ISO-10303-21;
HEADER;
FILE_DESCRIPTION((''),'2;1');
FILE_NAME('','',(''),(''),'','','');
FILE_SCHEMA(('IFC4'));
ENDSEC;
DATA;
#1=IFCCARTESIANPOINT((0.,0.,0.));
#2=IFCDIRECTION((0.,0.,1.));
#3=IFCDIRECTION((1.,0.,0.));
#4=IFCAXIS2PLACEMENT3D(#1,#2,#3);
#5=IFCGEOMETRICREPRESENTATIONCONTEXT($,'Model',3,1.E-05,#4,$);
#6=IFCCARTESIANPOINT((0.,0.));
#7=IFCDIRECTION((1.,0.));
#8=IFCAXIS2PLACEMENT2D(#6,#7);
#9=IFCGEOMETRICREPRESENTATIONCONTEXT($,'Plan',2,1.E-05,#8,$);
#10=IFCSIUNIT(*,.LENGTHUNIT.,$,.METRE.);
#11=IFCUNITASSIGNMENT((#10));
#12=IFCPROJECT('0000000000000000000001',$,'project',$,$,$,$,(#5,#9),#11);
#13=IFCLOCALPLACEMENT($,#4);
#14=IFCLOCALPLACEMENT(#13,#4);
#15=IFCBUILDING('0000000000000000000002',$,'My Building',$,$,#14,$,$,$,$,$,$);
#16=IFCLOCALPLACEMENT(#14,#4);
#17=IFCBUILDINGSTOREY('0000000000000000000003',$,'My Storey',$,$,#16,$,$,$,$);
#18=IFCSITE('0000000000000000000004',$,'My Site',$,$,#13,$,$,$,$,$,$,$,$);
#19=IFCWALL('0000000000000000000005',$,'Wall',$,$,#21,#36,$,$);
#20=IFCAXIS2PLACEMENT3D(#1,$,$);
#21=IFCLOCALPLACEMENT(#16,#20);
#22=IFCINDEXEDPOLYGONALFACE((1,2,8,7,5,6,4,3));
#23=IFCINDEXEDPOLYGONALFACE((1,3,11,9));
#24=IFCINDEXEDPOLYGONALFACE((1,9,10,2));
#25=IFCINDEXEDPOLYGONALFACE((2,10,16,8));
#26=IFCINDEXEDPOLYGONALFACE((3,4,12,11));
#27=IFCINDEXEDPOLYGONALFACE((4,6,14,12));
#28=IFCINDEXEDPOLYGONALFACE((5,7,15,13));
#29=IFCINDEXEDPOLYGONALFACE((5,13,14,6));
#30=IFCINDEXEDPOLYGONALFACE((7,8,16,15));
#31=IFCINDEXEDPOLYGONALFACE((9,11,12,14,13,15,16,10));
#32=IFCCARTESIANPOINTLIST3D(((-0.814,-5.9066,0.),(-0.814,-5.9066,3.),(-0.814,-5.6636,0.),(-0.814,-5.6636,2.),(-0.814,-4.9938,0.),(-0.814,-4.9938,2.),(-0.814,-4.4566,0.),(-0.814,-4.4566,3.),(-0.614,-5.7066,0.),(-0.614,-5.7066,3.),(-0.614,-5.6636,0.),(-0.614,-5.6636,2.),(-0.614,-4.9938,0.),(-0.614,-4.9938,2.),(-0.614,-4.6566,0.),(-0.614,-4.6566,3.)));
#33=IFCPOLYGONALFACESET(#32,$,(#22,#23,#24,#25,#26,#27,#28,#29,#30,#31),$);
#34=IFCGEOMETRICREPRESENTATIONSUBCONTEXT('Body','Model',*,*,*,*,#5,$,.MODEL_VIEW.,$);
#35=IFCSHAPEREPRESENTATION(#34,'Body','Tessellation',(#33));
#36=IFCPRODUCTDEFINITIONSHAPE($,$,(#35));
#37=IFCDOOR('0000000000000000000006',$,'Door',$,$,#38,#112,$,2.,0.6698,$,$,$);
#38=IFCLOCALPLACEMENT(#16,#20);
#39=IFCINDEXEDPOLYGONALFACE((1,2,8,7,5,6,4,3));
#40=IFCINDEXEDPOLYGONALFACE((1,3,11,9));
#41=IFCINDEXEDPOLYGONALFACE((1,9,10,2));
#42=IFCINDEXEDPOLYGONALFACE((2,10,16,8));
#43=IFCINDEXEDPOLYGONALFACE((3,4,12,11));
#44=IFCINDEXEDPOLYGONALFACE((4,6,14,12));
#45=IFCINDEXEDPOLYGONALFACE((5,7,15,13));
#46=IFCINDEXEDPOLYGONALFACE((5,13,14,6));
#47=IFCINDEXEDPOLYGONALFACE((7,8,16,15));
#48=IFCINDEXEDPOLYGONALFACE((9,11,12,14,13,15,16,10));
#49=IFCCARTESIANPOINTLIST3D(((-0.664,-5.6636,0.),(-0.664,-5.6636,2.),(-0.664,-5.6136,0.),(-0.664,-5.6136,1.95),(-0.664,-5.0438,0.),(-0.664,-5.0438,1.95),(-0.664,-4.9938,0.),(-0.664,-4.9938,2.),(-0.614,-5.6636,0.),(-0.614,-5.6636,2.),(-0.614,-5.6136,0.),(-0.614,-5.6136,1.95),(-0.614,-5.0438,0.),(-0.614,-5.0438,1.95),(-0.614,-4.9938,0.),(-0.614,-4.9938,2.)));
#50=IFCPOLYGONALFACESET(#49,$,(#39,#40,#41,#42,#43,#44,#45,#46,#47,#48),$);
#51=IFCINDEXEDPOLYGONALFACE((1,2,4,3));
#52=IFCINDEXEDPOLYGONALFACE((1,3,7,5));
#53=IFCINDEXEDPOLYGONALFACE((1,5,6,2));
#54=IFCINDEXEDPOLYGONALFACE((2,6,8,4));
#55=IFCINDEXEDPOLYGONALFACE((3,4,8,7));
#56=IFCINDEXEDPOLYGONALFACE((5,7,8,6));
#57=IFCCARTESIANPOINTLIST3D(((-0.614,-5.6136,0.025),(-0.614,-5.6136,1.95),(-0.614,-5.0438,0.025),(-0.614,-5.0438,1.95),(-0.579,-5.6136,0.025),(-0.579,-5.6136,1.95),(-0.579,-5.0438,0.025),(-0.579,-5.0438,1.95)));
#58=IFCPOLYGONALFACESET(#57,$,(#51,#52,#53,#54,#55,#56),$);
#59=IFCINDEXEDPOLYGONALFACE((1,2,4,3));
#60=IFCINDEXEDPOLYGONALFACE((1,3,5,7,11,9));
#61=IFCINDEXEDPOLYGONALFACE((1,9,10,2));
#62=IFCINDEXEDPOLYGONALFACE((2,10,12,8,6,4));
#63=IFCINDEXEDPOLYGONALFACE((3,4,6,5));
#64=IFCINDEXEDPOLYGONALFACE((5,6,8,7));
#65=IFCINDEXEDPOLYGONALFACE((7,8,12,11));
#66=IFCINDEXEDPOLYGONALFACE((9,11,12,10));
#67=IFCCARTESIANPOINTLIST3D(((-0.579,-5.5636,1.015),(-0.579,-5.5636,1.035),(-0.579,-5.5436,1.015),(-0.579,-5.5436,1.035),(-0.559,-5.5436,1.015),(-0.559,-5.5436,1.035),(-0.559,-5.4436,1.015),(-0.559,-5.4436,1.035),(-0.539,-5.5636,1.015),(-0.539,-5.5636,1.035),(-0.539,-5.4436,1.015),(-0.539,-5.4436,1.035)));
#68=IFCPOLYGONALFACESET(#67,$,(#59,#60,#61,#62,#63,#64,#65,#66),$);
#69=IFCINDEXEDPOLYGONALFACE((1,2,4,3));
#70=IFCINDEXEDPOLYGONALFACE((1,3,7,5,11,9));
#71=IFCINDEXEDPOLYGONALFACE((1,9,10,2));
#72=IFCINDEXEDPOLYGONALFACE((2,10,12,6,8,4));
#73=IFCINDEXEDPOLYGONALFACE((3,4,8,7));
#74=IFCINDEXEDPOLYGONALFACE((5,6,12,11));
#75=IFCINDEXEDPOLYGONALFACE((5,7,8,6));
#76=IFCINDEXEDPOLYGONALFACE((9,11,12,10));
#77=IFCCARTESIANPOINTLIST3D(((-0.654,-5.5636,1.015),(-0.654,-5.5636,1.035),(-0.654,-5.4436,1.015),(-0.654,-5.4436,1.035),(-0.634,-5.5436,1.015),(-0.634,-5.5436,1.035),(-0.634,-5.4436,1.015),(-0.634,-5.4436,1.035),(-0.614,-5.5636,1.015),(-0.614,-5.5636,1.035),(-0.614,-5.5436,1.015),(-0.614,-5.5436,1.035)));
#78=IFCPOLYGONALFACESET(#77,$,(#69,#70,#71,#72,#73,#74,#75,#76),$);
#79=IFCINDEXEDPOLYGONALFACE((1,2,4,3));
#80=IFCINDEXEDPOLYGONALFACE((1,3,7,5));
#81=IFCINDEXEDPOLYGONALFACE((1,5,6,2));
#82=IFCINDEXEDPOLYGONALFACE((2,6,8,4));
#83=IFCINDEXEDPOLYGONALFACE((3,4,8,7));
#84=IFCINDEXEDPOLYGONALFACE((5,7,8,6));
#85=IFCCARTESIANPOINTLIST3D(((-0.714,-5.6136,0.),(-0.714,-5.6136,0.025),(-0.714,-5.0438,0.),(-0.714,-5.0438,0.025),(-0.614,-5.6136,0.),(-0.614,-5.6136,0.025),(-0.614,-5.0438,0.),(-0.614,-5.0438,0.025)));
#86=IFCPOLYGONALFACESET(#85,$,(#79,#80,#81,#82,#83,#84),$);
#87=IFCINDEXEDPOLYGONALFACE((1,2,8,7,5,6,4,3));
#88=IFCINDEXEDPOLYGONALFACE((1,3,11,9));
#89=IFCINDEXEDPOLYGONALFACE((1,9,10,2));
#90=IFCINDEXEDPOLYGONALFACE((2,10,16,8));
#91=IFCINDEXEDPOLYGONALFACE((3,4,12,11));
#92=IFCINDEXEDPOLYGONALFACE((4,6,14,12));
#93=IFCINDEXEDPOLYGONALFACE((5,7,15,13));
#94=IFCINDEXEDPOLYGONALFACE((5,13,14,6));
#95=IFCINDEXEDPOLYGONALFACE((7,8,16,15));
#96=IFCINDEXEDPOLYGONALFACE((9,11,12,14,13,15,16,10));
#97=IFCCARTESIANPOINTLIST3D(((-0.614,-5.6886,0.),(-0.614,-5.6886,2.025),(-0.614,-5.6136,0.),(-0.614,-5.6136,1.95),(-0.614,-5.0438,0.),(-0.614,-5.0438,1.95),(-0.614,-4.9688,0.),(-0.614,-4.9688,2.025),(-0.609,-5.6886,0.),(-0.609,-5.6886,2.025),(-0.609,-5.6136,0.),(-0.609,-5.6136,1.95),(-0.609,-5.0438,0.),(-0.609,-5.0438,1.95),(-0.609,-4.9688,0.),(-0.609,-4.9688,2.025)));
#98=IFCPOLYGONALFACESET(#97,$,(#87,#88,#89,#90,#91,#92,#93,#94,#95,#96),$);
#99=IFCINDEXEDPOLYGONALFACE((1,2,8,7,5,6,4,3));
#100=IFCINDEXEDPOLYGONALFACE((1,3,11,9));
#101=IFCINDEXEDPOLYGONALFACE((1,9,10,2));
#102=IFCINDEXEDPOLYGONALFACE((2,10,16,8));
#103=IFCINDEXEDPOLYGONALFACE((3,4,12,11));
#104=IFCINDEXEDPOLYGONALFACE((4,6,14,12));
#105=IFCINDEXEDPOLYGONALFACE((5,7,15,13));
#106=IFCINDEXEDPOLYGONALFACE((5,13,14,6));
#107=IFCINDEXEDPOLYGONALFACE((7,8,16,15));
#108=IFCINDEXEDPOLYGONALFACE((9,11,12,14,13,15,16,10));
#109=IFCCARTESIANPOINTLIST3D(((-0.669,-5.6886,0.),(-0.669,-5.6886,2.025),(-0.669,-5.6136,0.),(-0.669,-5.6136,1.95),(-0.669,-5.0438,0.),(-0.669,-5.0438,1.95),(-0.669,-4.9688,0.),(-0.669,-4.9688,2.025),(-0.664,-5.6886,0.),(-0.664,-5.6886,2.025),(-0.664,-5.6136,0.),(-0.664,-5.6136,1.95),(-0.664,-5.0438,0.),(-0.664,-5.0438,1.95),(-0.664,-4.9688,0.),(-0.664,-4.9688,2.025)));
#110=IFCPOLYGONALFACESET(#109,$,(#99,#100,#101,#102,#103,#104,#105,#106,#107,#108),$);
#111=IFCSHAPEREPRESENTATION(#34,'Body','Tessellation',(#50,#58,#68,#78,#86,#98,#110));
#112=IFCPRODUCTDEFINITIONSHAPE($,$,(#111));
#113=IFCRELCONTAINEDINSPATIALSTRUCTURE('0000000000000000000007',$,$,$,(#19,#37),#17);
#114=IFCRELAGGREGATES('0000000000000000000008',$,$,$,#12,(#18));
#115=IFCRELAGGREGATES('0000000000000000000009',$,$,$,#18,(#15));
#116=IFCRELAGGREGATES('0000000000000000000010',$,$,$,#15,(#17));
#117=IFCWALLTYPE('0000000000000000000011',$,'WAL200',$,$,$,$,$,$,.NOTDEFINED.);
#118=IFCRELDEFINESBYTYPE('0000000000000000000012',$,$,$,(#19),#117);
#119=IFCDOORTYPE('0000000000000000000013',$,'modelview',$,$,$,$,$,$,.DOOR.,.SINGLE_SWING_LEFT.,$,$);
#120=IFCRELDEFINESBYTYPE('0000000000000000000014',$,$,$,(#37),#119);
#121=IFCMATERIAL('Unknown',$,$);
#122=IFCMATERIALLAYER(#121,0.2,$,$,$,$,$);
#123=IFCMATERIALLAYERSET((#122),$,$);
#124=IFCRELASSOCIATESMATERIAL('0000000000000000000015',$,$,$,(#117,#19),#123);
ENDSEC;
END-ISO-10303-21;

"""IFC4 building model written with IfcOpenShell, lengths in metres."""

from ifc_helpers import new_model, entity, si_unit, frame, origin_with_axes, origin_2d_with_axis, place, context, subcontext, project, spatial, line, indexed_curve, outline, extrude, shape, source, transform, mapped, material, layer, layer_set, layer_usage, type_object, type_shapes, element, fill, save


model = new_model("IFC4")

# Units and contexts
model_context = context("Model", 3, precision=1e-05, world=origin_with_axes())
plan_context = context("Plan", 2, precision=1e-05, world=origin_2d_with_axis())
body_context_1 = subcontext(model_context, "Body", "Model", "MODEL_VIEW")
body_context_2 = subcontext(plan_context, "Body", "Plan", "PLAN_VIEW")
ifc_project = project(units=[si_unit("LENGTHUNIT", "METRE")], contexts=[model_context, plan_context])

# Site, building, storey
site_placement = place(None, origin_with_axes())
site = spatial("IfcSite", under=ifc_project, at=site_placement, Name="My Site")
building_placement = place(site_placement, origin_with_axes())
building = spatial("IfcBuilding", under=site, at=building_placement, Name="My Building")
storey_placement = place(building_placement, origin_with_axes())
storey = spatial("IfcBuildingStorey", under=building, at=storey_placement, Name="My Storey")

# Shared definitions
ifc_material = material(Name="Unknown")

# Shared definitions
shared_shape_1 = source(origin_with_axes(), body_context_1, "Body", "SweptSolid", [
    extrude(outline(indexed_curve([(0.0, 0.0), (0.6698, 0.0), (0.6698, 2.0), (0.0, 2.0)], segments=[line(1, 2, 3, 4, 1)])), frame((0.0, -0.6, 0.0), z_axis=(0.0, -1.0, 0.0), x_axis=(1.0, 0.0, 0.0)), (0.0, 0.0, -1.0), 1.2),
])
door_type_1 = type_object("IfcDoorType", Name="modelview", OperationType="SINGLE_SWING_LEFT", PredefinedType="DOOR")
shared_shape_2 = source(origin_with_axes(), body_context_1, "Body", "SweptSolid", [
    extrude(outline(indexed_curve([(0.0, 0.0), (0.0, 2.0), (0.6698, 2.0), (0.6698, 0.0), (0.6198, 0.0), (0.6198, 1.95), (0.05, 1.95), (0.05, 0.0)], segments=[line(1, 2, 3, 4, 5, 6, 7, 8, 1)])), frame((0.0, 0.0, 0.0), z_axis=(0.0, -1.0, 0.0), x_axis=(1.0, 0.0, 0.0)), (0.0, 0.0, -1.0), 0.05),
    extrude(outline(indexed_curve([(0.0, 0.0), (0.5698, 0.0), (0.5698, 0.035), (0.0, 0.035)], segments=[line(1, 2, 3, 4, 1)])), frame((0.05, -0.035, 0.025), z_axis=(0.0, 0.0, 1.0), x_axis=(1.0, 0.0, 0.0)), (0.0, 0.0, 1.0), 1.925),
    extrude(outline(indexed_curve([(0.0, 0.0), (0.0, -0.04), (0.12, -0.04), (0.12, -0.02), (0.02, -0.02), (0.02, 0.0)], segments=[line(1, 2, 3, 4, 5, 6, 1)])), frame((0.1, -0.035, 1.015), z_axis=(0.0, 0.0, 1.0), x_axis=(1.0, 0.0, 0.0)), (0.0, 0.0, 1.0), 0.02),
    extrude(outline(indexed_curve([(0.0, 0.0), (0.0, 0.04), (0.12, 0.04), (0.12, 0.02), (0.02, 0.02), (0.02, 0.0)], segments=[line(1, 2, 3, 4, 5, 6, 1)])), frame((0.1, 0.0, 1.015), z_axis=(0.0, 0.0, 1.0), x_axis=(1.0, 0.0, 0.0)), (0.0, 0.0, 1.0), 0.02),
    extrude(outline(indexed_curve([(0.0, 0.0), (0.5698, 0.0), (0.5698, 0.1), (0.0, 0.1)], segments=[line(1, 2, 3, 4, 1)])), frame((0.05, 0.0, 0.0), z_axis=(0.0, 0.0, 1.0), x_axis=(1.0, 0.0, 0.0)), (0.0, 0.0, 1.0), 0.025),
    extrude(outline(indexed_curve([(0.0, 0.0), (0.0, 2.025), (0.7198, 2.025), (0.7198, 0.0), (0.6448, 0.0), (0.6448, 1.95), (0.075, 1.95), (0.075, 0.0)], segments=[line(1, 2, 3, 4, 5, 6, 7, 8, 1)])), frame((-0.025, -0.005, 0.0), z_axis=(0.0, -1.0, 0.0), x_axis=(1.0, 0.0, 0.0)), (0.0, 0.0, -1.0), 0.005),
    extrude(outline(indexed_curve([(0.0, 0.0), (0.0, 2.025), (0.7198, 2.025), (0.7198, 0.0), (0.6448, 0.0), (0.6448, 1.95), (0.075, 1.95), (0.075, 0.0)], segments=[line(1, 2, 3, 4, 5, 6, 7, 8, 1)])), frame((-0.025, 0.05, 0.0), z_axis=(0.0, -1.0, 0.0), x_axis=(1.0, 0.0, 0.0)), (0.0, 0.0, -1.0), 0.005),
])
shared_shape_3 = source(origin_with_axes(), body_context_2, "Body", "Curve2D", [
    entity("IfcIndexedPolyCurve", entity("IfcCartesianPointList2D", [[0.0, 0.0], [0.05, 0.0], [0.05, 0.05], [0.0, 0.05]]), [entity("IfcLineIndex", [1, 2, 3, 4, 1])]),
    entity("IfcIndexedPolyCurve", entity("IfcCartesianPointList2D", [[0.6698, 0.0], [0.6198, 0.0], [0.6198, 0.05], [0.6698, 0.05]]), [entity("IfcLineIndex", [1, 2, 3, 4, 1])]),
    entity("IfcIndexedPolyCurve", entity("IfcCartesianPointList2D", [[0.9047, -0.035], [0.3349, -0.035], [0.3349, 0.0], [0.9047, 0.0]]), [entity("IfcLineIndex", [1, 2, 3, 4, 1])]),
])
type_shapes(door_type_1, [shared_shape_2, shared_shape_3])

# Shared definitions
ifc_layer_1 = layer(ifc_material, 0.2)
ifc_layer_set_1 = layer_set([ifc_layer_1])
wall_type_1 = type_object("IfcWallType", Name="WAL200", PredefinedType="NOTDEFINED", material=ifc_layer_set_1)

# Wall, opening, door
ifc_layer_usage_1 = layer_usage(ifc_layer_set_1, "AXIS2", "POSITIVE", 0.0)
wall_1_placement = place(storey_placement, frame((-0.814, -4.4566, 0.0), z_axis=(0.0, 0.0, 1.0), x_axis=(0.0, -1.0, 0.0)))
wall_1 = element("IfcWall", 1, at=wall_1_placement, inside=storey, type_object=wall_type_1, material=ifc_layer_usage_1, Name="Wall", context=body_context_1, shape_type="SweptSolid", body=[
    extrude(outline(indexed_curve([(0.0, 0.0), (0.2, 0.2), (1.25, 0.2), (1.45, 0.0)], segments=[line(1, 2, 3, 4, 1)])), origin_with_axes(), (0.0, 0.0, 1.0), 3.0),
])
opening_1_placement = place(wall_1_placement, frame((1.2071, 0.2, 0.0), z_axis=(0.0, 0.0, 1.0), x_axis=(-1.0, 0.0, 0.0)))
opening_1 = element("IfcOpeningElement", 2, at=opening_1_placement, cuts=wall_1, PredefinedType="OPENING", context=body_context_1, shape_type="MappedRepresentation", body=[
    mapped(shared_shape_1, transform((0.0, 0.0, 0.0), x_axis=(1.0, 0.0, 0.0), y_axis=(0.0, 1.0, 0.0), z_axis=(0.0, 0.0, 1.0), scale=1.0)),
])
door_1_placement = place(opening_1_placement, frame((0.0, 0.0, 0.0), z_axis=(0.0, 0.0, 1.0), x_axis=(1.0, 0.0, 0.0)))
door_1 = element("IfcDoor", 3, at=door_1_placement, inside=storey, type_object=door_type_1, Name="Door", OverallHeight=2.0, OverallWidth=0.6698, shapes=[
    shape(body_context_1, "Body", "MappedRepresentation", [mapped(shared_shape_2, transform((0.0, 0.0, 0.0), x_axis=(1.0, 0.0, 0.0), y_axis=(0.0, 1.0, 0.0), z_axis=(0.0, 0.0, 1.0), scale=1.0))]),
    shape(body_context_2, "Body", "MappedRepresentation", [mapped(shared_shape_3, transform((0.0, 0.0, 0.0), x_axis=(1.0, 0.0, 0.0), y_axis=(0.0, 1.0, 0.0), z_axis=(0.0, 0.0, 1.0), scale=1.0))]),
])
fill(opening_1, door_1)

save(model, "model.ifc")
